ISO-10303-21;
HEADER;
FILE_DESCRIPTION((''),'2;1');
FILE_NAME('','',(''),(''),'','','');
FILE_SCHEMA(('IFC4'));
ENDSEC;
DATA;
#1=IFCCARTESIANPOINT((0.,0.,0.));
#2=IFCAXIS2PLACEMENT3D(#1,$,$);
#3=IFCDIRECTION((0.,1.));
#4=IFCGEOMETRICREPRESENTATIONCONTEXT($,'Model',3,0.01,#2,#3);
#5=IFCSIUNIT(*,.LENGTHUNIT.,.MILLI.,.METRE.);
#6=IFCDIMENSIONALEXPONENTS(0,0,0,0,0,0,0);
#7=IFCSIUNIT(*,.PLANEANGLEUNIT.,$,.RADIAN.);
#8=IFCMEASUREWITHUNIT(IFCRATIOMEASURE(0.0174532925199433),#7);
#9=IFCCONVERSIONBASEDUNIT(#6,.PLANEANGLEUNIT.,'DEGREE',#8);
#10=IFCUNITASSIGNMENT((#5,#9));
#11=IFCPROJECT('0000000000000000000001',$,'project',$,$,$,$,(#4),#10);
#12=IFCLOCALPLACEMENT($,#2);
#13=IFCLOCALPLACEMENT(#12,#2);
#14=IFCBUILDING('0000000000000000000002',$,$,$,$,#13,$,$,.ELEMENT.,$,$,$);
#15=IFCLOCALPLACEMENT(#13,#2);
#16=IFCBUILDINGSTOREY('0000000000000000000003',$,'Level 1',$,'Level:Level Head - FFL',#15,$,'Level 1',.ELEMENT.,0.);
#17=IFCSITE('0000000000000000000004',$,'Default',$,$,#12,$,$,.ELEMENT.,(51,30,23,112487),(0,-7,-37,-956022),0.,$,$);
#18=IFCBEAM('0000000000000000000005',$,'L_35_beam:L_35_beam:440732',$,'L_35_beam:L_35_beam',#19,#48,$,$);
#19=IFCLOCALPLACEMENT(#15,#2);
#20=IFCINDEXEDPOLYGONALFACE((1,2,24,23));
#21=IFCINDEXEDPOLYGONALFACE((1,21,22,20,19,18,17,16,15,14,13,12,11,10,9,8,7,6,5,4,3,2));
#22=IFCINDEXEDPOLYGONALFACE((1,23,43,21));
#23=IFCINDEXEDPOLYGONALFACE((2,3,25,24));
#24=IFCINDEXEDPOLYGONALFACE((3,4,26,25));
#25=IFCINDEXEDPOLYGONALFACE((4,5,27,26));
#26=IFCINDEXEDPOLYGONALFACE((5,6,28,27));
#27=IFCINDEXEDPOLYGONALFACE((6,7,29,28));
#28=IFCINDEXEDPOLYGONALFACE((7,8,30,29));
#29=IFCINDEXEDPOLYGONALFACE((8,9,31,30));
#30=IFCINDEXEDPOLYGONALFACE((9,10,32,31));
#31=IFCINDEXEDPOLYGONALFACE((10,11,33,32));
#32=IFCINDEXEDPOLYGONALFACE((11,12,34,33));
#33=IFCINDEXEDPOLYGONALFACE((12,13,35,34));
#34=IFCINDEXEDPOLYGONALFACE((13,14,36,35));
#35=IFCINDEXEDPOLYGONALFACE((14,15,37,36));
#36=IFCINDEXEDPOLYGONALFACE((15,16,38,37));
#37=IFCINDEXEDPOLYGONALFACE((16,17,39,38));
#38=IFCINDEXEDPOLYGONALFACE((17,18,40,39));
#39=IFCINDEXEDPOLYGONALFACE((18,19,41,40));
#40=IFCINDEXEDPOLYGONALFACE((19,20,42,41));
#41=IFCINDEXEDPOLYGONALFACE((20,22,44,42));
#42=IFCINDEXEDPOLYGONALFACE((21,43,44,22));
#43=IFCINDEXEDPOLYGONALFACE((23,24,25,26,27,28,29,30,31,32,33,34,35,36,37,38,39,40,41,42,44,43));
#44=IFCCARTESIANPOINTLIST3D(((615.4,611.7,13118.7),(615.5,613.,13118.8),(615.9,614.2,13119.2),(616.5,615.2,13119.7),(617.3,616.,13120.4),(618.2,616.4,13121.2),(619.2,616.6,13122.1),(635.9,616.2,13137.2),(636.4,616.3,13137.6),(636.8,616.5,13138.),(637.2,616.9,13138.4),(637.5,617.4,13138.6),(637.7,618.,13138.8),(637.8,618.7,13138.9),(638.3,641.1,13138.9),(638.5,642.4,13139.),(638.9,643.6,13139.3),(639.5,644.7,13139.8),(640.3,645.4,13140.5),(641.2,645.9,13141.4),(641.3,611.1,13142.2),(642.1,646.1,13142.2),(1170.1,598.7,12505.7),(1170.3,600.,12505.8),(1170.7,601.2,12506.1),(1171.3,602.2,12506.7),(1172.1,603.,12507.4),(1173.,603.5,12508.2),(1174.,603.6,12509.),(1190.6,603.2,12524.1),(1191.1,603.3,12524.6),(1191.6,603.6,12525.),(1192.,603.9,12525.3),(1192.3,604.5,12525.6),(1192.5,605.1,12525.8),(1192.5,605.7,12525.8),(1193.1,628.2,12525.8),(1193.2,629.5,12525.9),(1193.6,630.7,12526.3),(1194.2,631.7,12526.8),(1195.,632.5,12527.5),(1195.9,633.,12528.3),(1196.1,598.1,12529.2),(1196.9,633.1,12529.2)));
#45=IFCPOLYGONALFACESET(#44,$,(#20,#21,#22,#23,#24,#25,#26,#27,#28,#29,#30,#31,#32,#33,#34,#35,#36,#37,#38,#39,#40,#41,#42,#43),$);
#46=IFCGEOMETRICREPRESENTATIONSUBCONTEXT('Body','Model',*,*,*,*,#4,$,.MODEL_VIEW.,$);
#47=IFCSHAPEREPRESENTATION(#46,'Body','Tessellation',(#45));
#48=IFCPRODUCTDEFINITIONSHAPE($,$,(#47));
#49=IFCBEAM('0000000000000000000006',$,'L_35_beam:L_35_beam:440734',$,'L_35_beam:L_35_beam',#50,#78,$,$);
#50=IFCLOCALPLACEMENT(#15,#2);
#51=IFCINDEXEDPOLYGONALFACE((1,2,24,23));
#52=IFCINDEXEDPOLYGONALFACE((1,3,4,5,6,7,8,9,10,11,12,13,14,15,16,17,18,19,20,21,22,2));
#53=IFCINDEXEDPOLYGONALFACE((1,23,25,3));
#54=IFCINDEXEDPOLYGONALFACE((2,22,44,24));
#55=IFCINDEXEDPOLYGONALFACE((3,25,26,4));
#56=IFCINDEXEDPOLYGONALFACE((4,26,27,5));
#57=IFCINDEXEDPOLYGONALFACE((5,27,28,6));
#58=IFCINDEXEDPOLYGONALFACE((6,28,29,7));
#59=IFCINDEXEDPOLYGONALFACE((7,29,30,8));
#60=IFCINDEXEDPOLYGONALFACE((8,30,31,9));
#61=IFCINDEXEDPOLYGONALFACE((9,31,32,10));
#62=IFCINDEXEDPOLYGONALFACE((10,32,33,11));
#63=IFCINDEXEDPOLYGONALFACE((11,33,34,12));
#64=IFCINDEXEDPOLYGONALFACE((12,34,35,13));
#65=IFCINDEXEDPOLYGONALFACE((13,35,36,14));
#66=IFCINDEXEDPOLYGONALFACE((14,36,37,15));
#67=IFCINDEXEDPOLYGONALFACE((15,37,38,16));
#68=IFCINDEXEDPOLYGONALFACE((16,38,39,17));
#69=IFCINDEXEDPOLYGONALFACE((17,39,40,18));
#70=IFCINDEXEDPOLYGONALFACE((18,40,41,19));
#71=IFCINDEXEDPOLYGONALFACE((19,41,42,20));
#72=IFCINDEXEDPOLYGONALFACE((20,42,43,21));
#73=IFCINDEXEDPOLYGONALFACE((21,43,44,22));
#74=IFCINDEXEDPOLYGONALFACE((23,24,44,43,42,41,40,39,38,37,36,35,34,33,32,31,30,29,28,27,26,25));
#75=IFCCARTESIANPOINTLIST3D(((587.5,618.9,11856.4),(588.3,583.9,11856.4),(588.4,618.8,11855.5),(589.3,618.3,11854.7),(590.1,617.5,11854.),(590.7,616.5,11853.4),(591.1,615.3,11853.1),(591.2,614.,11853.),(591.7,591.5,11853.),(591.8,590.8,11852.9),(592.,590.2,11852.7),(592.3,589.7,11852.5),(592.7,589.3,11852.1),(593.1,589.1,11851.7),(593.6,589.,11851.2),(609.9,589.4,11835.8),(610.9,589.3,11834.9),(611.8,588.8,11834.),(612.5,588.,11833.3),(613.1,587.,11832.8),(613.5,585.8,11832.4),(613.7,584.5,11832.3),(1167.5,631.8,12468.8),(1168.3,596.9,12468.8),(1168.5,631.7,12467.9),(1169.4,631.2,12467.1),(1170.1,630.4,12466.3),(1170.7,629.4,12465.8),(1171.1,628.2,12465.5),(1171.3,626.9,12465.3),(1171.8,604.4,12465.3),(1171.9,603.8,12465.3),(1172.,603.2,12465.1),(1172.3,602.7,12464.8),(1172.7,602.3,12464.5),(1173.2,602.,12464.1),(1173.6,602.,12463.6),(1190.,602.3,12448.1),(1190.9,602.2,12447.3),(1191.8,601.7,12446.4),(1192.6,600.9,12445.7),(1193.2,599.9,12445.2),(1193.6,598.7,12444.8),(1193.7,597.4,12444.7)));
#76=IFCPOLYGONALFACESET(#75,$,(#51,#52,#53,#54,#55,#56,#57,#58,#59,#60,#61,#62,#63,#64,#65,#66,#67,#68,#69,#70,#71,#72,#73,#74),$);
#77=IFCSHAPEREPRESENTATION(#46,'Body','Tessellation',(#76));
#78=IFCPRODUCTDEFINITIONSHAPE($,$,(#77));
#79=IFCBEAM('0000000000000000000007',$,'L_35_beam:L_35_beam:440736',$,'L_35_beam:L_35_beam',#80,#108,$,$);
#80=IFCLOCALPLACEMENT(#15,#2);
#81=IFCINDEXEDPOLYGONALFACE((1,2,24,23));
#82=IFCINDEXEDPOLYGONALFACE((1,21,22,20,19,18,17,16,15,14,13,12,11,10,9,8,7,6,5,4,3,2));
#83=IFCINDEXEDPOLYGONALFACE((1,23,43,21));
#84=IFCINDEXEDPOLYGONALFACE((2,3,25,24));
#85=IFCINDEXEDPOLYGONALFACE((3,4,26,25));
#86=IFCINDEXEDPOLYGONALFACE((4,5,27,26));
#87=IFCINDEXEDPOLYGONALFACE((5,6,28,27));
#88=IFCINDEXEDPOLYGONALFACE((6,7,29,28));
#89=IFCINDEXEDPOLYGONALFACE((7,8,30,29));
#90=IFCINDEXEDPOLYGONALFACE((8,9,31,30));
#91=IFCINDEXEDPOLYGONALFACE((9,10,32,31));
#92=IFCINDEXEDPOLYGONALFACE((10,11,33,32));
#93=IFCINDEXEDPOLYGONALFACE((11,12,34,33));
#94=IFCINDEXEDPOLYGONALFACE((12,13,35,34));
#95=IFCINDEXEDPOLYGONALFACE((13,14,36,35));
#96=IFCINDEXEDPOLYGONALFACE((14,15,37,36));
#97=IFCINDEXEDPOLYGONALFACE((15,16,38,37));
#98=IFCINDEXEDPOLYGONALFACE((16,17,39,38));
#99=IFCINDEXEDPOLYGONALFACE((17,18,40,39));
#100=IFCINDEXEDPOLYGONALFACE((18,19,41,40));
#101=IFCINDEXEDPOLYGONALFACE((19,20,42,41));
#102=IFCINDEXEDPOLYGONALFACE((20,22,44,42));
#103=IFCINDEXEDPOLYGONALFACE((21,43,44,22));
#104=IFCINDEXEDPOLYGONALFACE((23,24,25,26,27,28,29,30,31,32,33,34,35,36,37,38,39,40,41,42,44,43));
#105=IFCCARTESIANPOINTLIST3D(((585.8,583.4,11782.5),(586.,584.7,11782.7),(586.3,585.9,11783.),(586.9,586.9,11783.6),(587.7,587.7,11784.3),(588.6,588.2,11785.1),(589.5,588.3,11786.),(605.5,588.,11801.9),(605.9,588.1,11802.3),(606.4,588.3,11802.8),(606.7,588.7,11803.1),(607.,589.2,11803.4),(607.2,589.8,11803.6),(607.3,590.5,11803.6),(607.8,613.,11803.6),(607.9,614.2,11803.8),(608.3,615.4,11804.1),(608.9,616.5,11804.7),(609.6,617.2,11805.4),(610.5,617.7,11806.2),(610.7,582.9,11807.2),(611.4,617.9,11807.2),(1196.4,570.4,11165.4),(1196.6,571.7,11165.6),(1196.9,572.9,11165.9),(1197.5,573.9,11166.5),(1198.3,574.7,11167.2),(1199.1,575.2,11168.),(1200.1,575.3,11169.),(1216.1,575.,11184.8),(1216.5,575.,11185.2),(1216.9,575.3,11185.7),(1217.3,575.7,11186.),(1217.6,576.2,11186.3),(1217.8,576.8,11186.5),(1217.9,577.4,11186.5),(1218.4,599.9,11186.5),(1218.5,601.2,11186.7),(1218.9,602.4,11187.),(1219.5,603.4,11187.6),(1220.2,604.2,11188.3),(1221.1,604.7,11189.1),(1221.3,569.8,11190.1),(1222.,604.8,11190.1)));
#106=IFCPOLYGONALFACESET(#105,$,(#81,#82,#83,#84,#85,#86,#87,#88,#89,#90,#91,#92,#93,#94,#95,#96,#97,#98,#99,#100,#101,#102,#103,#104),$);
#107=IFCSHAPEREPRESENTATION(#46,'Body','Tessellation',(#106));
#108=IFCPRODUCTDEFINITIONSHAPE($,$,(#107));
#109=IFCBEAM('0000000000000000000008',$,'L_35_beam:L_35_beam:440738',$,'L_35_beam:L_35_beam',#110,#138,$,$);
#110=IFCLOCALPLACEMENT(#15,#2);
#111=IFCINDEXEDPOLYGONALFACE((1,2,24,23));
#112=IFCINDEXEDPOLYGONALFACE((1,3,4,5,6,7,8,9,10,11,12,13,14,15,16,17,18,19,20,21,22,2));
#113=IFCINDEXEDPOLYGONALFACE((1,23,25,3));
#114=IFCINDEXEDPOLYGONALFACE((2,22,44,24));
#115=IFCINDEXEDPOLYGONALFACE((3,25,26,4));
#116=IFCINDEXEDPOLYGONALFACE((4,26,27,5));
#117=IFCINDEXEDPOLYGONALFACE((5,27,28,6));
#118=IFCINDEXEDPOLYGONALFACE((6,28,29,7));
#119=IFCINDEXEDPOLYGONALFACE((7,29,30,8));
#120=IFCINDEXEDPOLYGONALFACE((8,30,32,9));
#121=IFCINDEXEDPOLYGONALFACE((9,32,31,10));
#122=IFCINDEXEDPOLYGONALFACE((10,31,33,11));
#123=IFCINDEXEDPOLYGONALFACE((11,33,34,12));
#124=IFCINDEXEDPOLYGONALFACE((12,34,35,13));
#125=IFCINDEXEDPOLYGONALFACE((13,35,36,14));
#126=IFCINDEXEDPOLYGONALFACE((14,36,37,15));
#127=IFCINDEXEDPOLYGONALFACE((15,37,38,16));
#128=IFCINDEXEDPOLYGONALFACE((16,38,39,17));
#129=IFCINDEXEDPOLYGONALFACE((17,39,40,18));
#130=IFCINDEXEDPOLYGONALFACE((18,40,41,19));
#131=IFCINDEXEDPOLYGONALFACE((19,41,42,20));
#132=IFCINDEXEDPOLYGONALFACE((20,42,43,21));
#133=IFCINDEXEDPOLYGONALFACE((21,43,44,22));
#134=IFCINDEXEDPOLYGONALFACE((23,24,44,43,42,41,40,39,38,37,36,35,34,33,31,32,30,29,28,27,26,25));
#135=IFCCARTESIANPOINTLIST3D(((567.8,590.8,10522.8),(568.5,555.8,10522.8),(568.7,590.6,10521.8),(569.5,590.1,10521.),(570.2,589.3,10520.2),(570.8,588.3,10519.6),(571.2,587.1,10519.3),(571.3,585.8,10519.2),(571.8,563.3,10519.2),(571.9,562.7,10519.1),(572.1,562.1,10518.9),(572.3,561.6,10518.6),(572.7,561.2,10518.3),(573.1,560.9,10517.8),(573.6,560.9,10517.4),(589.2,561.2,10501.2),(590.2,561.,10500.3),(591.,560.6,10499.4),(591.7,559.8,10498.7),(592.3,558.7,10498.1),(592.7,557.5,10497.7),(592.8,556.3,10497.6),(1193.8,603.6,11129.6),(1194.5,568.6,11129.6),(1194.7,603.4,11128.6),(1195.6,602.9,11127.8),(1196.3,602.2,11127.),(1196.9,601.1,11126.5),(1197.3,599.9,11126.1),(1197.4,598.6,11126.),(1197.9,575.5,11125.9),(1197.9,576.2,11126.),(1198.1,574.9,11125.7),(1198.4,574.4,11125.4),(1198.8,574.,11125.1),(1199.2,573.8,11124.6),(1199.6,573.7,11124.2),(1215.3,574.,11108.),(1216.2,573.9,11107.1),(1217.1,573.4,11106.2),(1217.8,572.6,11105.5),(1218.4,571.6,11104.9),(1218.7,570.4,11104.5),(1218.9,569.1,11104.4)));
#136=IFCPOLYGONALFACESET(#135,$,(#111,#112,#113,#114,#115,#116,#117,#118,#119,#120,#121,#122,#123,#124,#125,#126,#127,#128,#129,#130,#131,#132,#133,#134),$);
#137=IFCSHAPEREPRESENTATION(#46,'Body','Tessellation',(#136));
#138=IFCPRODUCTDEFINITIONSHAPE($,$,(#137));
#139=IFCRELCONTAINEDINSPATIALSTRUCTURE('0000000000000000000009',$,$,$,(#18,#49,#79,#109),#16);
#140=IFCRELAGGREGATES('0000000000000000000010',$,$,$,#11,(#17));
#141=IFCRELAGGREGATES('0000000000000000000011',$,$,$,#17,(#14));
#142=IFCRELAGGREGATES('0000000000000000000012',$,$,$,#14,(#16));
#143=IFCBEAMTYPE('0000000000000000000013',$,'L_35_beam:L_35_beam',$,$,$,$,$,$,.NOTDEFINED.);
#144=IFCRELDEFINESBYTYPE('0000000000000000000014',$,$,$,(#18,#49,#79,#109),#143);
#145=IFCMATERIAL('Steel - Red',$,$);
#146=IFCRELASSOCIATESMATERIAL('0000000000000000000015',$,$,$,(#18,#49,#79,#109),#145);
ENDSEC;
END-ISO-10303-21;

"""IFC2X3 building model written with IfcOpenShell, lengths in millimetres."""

from ifc_helpers import new_model, entity, si_unit, converted_unit, direction, frame, frame_2d, origin, place, context, subcontext, project, spatial, polyline, circle_curve, parameter, trimmed, segment, composite_curve, outline, extrude, material, type_object, element, save


model = new_model("IFC2X3")

# Units and contexts
model_context = context("Model", 3, precision=0.01, world=origin(), true_north=direction((0.0, 1.0)))
body_context = subcontext(model_context, "Body", "Model", "MODEL_VIEW")
ifc_project = project(units=[si_unit("LENGTHUNIT", "METRE", prefix="MILLI"), converted_unit("PLANEANGLEUNIT", "DEGREE", entity("IfcRatioMeasure", 0.0174532925199433), si_unit("PLANEANGLEUNIT", "RADIAN"), dimensions=[0, 0, 0, 0, 0, 0, 0])], contexts=[model_context])

# Site, building, storey
site_placement = place(None, origin())
site = spatial("IfcSite", under=ifc_project, at=site_placement, Name="Default", CompositionType="ELEMENT", RefLatitude=(51, 30, 23, 112487), RefLongitude=(0, -7, -37, -956022), RefElevation=0.0)
building_placement = place(site_placement, origin())
building = spatial("IfcBuilding", under=site, at=building_placement, CompositionType="ELEMENT")
storey_placement = place(building_placement, origin())
storey = spatial("IfcBuildingStorey", under=building, at=storey_placement, Name="Level 1", ObjectType="Level:Level Head - FFL", LongName="Level 1", CompositionType="ELEMENT", Elevation=0.0)

# Beams
ifc_material_1 = material(Name="Steel - Red")
beam_type_1 = type_object("IfcBeamType", Name="L_35_beam:L_35_beam", PredefinedType="NOTDEFINED")
beam_1_placement = place(storey_placement, frame((1210.2, 589.8, 12487.3), z_axis=(0.741553, 0.014172, 0.670744), x_axis=(-0.670894, 0.015665, 0.741388)))
element("IfcBeam", 1, at=beam_1_placement, inside=storey, type_object=beam_type_1, material=ifc_material_1, Name="L_35_beam:L_35_beam:440732", ObjectType="L_35_beam:L_35_beam", context=body_context, shape_type="SweptSolid", body=[
    extrude(outline(composite_curve([segment(polyline([(-23.2, -11.8), (11.8, -11.8)]), True, "CONTINUOUS"), segment(polyline([(11.8, -11.8), (11.8, 23.2)]), True, "CONTINUOUS"), segment(trimmed(circle_curve(frame_2d((11.8, 18.2), x_axis=(0.0, 1.0)), 5.0), [parameter(0.0)], [parameter(90.0)], True, "PARAMETER"), True, "CONTINUOUS"), segment(polyline([(6.8, 18.2), (6.8, -4.3)]), True, "CONTINUOUS"), segment(trimmed(circle_curve(frame_2d((4.3, -4.3), x_axis=(1.0, 0.0)), 2.5), [parameter(270.0)], [parameter(0.0)], True, "PARAMETER"), False, "CONTINUOUS"), segment(polyline([(4.3, -6.8), (-18.2, -6.8)]), True, "CONTINUOUS"), segment(trimmed(circle_curve(frame_2d((-18.2, -11.8), x_axis=(0.0, 1.0)), 5.0), [parameter(0.0)], [parameter(90.0)], True, "PARAMETER"), True, "CONTINUOUS")], self_intersect=False)), frame((40.6, -19.6, 6.3), z_axis=(1.0, 0.0, 0.0), x_axis=(0.0, 0.031479, 0.999504)), (0.0, 0.0, 1.0), 826.9),
])
beam_2_placement = place(storey_placement, frame((1210.2, 589.8, 12487.3), z_axis=(0.726096, -0.014525, -0.68744), x_axis=(-0.687593, -0.015339, -0.725934)))
element("IfcBeam", 2, at=beam_2_placement, inside=storey, type_object=beam_type_1, material=ifc_material_1, Name="L_35_beam:L_35_beam:440734", ObjectType="L_35_beam:L_35_beam", context=body_context, shape_type="SweptSolid", body=[
    extrude(outline(composite_curve([segment(polyline([(-4.3, 6.8), (18.2, 6.8)]), True, "CONTINUOUS"), segment(trimmed(circle_curve(frame_2d((18.2, 11.8), x_axis=(0.0, -1.0)), 5.0), [parameter(0.0)], [parameter(90.0)], True, "PARAMETER"), True, "CONTINUOUS"), segment(polyline([(23.2, 11.8), (-11.8, 11.8)]), True, "CONTINUOUS"), segment(polyline([(-11.8, 11.8), (-11.8, -23.2)]), True, "CONTINUOUS"), segment(trimmed(circle_curve(frame_2d((-11.8, -18.2), x_axis=(0.0, -1.0)), 5.0), [parameter(0.0)], [parameter(90.0)], True, "PARAMETER"), True, "CONTINUOUS"), segment(polyline([(-6.8, -18.2), (-6.8, 4.3)]), True, "CONTINUOUS"), segment(trimmed(circle_curve(frame_2d((-4.3, 4.3), x_axis=(-1.0, 0.0)), 2.5), [parameter(270.0)], [parameter(0.0)], True, "PARAMETER"), False, "CONTINUOUS")], self_intersect=False)), frame((42.1, 19.6, -6.3), z_axis=(1.0, 0.0, 0.0), x_axis=(0.0, 0.030715, 0.999528)), (0.0, 0.0, 1.0), 843.6),
])
beam_3_placement = place(storey_placement, frame((1238.5, 561.5, 11147.6), z_axis=(0.710924, 0.014856, 0.703112), x_axis=(-0.703269, 0.015018, 0.710765)))
element("IfcBeam", 3, at=beam_3_placement, inside=storey, type_object=beam_type_1, material=ifc_material_1, Name="L_35_beam:L_35_beam:440736", ObjectType="L_35_beam:L_35_beam", context=body_context, shape_type="SweptSolid", body=[
    extrude(outline(composite_curve([segment(polyline([(-23.2, -11.8), (11.8, -11.8)]), True, "CONTINUOUS"), segment(polyline([(11.8, -11.8), (11.8, 23.2)]), True, "CONTINUOUS"), segment(trimmed(circle_curve(frame_2d((11.8, 18.2), x_axis=(0.0, 1.0)), 5.0), [parameter(0.0)], [parameter(90.0)], True, "PARAMETER"), True, "CONTINUOUS"), segment(polyline([(6.8, 18.2), (6.8, -4.3)]), True, "CONTINUOUS"), segment(trimmed(circle_curve(frame_2d((4.3, -4.3), x_axis=(1.0, 0.0)), 2.5), [parameter(270.0)], [parameter(0.0)], True, "PARAMETER"), False, "CONTINUOUS"), segment(polyline([(4.3, -6.8), (-18.2, -6.8)]), True, "CONTINUOUS"), segment(trimmed(circle_curve(frame_2d((-18.2, -11.8), x_axis=(0.0, 1.0)), 5.0), [parameter(0.0)], [parameter(90.0)], True, "PARAMETER"), True, "CONTINUOUS")], self_intersect=False)), frame((42.4, -19.6, 6.3), z_axis=(1.0, 0.0, 0.0), x_axis=(0.0, 0.030031, 0.999549)), (0.0, 0.0, 1.0), 868.2),
])
beam_4_placement = place(storey_placement, frame((1238.5, 561.5, 11147.6), z_axis=(-0.695761, -0.014249, 0.718132), x_axis=(-0.717982, -0.014704, -0.695907)))
element("IfcBeam", 4, at=beam_4_placement, inside=storey, type_object=beam_type_1, material=ifc_material_1, Name="L_35_beam:L_35_beam:440738", ObjectType="L_35_beam:L_35_beam", context=body_context, shape_type="SweptSolid", body=[
    extrude(outline(composite_curve([segment(polyline([(-23.2, -11.8), (11.8, -11.8)]), True, "CONTINUOUS"), segment(polyline([(11.8, -11.8), (11.8, 23.2)]), True, "CONTINUOUS"), segment(trimmed(circle_curve(frame_2d((11.8, 18.2), x_axis=(0.0, 1.0)), 5.0), [parameter(0.0)], [parameter(90.0)], True, "PARAMETER"), True, "CONTINUOUS"), segment(polyline([(6.8, 18.2), (6.8, -4.3)]), True, "CONTINUOUS"), segment(trimmed(circle_curve(frame_2d((4.3, -4.3), x_axis=(1.0, 0.0)), 2.5), [parameter(270.0)], [parameter(0.0)], True, "PARAMETER"), False, "CONTINUOUS"), segment(polyline([(4.3, -6.8), (-18.2, -6.8)]), True, "CONTINUOUS"), segment(trimmed(circle_curve(frame_2d((-18.2, -11.8), x_axis=(0.0, 1.0)), 5.0), [parameter(0.0)], [parameter(90.0)], True, "PARAMETER"), True, "CONTINUOUS")], self_intersect=False)), frame((44.0, -19.8, 5.7), z_axis=(1.0, 0.0, 0.0), x_axis=(0.0, 0.0, 1.0)), (0.0, 0.0, 1.0), 872.0),
])

save(model, "model.ifc")
